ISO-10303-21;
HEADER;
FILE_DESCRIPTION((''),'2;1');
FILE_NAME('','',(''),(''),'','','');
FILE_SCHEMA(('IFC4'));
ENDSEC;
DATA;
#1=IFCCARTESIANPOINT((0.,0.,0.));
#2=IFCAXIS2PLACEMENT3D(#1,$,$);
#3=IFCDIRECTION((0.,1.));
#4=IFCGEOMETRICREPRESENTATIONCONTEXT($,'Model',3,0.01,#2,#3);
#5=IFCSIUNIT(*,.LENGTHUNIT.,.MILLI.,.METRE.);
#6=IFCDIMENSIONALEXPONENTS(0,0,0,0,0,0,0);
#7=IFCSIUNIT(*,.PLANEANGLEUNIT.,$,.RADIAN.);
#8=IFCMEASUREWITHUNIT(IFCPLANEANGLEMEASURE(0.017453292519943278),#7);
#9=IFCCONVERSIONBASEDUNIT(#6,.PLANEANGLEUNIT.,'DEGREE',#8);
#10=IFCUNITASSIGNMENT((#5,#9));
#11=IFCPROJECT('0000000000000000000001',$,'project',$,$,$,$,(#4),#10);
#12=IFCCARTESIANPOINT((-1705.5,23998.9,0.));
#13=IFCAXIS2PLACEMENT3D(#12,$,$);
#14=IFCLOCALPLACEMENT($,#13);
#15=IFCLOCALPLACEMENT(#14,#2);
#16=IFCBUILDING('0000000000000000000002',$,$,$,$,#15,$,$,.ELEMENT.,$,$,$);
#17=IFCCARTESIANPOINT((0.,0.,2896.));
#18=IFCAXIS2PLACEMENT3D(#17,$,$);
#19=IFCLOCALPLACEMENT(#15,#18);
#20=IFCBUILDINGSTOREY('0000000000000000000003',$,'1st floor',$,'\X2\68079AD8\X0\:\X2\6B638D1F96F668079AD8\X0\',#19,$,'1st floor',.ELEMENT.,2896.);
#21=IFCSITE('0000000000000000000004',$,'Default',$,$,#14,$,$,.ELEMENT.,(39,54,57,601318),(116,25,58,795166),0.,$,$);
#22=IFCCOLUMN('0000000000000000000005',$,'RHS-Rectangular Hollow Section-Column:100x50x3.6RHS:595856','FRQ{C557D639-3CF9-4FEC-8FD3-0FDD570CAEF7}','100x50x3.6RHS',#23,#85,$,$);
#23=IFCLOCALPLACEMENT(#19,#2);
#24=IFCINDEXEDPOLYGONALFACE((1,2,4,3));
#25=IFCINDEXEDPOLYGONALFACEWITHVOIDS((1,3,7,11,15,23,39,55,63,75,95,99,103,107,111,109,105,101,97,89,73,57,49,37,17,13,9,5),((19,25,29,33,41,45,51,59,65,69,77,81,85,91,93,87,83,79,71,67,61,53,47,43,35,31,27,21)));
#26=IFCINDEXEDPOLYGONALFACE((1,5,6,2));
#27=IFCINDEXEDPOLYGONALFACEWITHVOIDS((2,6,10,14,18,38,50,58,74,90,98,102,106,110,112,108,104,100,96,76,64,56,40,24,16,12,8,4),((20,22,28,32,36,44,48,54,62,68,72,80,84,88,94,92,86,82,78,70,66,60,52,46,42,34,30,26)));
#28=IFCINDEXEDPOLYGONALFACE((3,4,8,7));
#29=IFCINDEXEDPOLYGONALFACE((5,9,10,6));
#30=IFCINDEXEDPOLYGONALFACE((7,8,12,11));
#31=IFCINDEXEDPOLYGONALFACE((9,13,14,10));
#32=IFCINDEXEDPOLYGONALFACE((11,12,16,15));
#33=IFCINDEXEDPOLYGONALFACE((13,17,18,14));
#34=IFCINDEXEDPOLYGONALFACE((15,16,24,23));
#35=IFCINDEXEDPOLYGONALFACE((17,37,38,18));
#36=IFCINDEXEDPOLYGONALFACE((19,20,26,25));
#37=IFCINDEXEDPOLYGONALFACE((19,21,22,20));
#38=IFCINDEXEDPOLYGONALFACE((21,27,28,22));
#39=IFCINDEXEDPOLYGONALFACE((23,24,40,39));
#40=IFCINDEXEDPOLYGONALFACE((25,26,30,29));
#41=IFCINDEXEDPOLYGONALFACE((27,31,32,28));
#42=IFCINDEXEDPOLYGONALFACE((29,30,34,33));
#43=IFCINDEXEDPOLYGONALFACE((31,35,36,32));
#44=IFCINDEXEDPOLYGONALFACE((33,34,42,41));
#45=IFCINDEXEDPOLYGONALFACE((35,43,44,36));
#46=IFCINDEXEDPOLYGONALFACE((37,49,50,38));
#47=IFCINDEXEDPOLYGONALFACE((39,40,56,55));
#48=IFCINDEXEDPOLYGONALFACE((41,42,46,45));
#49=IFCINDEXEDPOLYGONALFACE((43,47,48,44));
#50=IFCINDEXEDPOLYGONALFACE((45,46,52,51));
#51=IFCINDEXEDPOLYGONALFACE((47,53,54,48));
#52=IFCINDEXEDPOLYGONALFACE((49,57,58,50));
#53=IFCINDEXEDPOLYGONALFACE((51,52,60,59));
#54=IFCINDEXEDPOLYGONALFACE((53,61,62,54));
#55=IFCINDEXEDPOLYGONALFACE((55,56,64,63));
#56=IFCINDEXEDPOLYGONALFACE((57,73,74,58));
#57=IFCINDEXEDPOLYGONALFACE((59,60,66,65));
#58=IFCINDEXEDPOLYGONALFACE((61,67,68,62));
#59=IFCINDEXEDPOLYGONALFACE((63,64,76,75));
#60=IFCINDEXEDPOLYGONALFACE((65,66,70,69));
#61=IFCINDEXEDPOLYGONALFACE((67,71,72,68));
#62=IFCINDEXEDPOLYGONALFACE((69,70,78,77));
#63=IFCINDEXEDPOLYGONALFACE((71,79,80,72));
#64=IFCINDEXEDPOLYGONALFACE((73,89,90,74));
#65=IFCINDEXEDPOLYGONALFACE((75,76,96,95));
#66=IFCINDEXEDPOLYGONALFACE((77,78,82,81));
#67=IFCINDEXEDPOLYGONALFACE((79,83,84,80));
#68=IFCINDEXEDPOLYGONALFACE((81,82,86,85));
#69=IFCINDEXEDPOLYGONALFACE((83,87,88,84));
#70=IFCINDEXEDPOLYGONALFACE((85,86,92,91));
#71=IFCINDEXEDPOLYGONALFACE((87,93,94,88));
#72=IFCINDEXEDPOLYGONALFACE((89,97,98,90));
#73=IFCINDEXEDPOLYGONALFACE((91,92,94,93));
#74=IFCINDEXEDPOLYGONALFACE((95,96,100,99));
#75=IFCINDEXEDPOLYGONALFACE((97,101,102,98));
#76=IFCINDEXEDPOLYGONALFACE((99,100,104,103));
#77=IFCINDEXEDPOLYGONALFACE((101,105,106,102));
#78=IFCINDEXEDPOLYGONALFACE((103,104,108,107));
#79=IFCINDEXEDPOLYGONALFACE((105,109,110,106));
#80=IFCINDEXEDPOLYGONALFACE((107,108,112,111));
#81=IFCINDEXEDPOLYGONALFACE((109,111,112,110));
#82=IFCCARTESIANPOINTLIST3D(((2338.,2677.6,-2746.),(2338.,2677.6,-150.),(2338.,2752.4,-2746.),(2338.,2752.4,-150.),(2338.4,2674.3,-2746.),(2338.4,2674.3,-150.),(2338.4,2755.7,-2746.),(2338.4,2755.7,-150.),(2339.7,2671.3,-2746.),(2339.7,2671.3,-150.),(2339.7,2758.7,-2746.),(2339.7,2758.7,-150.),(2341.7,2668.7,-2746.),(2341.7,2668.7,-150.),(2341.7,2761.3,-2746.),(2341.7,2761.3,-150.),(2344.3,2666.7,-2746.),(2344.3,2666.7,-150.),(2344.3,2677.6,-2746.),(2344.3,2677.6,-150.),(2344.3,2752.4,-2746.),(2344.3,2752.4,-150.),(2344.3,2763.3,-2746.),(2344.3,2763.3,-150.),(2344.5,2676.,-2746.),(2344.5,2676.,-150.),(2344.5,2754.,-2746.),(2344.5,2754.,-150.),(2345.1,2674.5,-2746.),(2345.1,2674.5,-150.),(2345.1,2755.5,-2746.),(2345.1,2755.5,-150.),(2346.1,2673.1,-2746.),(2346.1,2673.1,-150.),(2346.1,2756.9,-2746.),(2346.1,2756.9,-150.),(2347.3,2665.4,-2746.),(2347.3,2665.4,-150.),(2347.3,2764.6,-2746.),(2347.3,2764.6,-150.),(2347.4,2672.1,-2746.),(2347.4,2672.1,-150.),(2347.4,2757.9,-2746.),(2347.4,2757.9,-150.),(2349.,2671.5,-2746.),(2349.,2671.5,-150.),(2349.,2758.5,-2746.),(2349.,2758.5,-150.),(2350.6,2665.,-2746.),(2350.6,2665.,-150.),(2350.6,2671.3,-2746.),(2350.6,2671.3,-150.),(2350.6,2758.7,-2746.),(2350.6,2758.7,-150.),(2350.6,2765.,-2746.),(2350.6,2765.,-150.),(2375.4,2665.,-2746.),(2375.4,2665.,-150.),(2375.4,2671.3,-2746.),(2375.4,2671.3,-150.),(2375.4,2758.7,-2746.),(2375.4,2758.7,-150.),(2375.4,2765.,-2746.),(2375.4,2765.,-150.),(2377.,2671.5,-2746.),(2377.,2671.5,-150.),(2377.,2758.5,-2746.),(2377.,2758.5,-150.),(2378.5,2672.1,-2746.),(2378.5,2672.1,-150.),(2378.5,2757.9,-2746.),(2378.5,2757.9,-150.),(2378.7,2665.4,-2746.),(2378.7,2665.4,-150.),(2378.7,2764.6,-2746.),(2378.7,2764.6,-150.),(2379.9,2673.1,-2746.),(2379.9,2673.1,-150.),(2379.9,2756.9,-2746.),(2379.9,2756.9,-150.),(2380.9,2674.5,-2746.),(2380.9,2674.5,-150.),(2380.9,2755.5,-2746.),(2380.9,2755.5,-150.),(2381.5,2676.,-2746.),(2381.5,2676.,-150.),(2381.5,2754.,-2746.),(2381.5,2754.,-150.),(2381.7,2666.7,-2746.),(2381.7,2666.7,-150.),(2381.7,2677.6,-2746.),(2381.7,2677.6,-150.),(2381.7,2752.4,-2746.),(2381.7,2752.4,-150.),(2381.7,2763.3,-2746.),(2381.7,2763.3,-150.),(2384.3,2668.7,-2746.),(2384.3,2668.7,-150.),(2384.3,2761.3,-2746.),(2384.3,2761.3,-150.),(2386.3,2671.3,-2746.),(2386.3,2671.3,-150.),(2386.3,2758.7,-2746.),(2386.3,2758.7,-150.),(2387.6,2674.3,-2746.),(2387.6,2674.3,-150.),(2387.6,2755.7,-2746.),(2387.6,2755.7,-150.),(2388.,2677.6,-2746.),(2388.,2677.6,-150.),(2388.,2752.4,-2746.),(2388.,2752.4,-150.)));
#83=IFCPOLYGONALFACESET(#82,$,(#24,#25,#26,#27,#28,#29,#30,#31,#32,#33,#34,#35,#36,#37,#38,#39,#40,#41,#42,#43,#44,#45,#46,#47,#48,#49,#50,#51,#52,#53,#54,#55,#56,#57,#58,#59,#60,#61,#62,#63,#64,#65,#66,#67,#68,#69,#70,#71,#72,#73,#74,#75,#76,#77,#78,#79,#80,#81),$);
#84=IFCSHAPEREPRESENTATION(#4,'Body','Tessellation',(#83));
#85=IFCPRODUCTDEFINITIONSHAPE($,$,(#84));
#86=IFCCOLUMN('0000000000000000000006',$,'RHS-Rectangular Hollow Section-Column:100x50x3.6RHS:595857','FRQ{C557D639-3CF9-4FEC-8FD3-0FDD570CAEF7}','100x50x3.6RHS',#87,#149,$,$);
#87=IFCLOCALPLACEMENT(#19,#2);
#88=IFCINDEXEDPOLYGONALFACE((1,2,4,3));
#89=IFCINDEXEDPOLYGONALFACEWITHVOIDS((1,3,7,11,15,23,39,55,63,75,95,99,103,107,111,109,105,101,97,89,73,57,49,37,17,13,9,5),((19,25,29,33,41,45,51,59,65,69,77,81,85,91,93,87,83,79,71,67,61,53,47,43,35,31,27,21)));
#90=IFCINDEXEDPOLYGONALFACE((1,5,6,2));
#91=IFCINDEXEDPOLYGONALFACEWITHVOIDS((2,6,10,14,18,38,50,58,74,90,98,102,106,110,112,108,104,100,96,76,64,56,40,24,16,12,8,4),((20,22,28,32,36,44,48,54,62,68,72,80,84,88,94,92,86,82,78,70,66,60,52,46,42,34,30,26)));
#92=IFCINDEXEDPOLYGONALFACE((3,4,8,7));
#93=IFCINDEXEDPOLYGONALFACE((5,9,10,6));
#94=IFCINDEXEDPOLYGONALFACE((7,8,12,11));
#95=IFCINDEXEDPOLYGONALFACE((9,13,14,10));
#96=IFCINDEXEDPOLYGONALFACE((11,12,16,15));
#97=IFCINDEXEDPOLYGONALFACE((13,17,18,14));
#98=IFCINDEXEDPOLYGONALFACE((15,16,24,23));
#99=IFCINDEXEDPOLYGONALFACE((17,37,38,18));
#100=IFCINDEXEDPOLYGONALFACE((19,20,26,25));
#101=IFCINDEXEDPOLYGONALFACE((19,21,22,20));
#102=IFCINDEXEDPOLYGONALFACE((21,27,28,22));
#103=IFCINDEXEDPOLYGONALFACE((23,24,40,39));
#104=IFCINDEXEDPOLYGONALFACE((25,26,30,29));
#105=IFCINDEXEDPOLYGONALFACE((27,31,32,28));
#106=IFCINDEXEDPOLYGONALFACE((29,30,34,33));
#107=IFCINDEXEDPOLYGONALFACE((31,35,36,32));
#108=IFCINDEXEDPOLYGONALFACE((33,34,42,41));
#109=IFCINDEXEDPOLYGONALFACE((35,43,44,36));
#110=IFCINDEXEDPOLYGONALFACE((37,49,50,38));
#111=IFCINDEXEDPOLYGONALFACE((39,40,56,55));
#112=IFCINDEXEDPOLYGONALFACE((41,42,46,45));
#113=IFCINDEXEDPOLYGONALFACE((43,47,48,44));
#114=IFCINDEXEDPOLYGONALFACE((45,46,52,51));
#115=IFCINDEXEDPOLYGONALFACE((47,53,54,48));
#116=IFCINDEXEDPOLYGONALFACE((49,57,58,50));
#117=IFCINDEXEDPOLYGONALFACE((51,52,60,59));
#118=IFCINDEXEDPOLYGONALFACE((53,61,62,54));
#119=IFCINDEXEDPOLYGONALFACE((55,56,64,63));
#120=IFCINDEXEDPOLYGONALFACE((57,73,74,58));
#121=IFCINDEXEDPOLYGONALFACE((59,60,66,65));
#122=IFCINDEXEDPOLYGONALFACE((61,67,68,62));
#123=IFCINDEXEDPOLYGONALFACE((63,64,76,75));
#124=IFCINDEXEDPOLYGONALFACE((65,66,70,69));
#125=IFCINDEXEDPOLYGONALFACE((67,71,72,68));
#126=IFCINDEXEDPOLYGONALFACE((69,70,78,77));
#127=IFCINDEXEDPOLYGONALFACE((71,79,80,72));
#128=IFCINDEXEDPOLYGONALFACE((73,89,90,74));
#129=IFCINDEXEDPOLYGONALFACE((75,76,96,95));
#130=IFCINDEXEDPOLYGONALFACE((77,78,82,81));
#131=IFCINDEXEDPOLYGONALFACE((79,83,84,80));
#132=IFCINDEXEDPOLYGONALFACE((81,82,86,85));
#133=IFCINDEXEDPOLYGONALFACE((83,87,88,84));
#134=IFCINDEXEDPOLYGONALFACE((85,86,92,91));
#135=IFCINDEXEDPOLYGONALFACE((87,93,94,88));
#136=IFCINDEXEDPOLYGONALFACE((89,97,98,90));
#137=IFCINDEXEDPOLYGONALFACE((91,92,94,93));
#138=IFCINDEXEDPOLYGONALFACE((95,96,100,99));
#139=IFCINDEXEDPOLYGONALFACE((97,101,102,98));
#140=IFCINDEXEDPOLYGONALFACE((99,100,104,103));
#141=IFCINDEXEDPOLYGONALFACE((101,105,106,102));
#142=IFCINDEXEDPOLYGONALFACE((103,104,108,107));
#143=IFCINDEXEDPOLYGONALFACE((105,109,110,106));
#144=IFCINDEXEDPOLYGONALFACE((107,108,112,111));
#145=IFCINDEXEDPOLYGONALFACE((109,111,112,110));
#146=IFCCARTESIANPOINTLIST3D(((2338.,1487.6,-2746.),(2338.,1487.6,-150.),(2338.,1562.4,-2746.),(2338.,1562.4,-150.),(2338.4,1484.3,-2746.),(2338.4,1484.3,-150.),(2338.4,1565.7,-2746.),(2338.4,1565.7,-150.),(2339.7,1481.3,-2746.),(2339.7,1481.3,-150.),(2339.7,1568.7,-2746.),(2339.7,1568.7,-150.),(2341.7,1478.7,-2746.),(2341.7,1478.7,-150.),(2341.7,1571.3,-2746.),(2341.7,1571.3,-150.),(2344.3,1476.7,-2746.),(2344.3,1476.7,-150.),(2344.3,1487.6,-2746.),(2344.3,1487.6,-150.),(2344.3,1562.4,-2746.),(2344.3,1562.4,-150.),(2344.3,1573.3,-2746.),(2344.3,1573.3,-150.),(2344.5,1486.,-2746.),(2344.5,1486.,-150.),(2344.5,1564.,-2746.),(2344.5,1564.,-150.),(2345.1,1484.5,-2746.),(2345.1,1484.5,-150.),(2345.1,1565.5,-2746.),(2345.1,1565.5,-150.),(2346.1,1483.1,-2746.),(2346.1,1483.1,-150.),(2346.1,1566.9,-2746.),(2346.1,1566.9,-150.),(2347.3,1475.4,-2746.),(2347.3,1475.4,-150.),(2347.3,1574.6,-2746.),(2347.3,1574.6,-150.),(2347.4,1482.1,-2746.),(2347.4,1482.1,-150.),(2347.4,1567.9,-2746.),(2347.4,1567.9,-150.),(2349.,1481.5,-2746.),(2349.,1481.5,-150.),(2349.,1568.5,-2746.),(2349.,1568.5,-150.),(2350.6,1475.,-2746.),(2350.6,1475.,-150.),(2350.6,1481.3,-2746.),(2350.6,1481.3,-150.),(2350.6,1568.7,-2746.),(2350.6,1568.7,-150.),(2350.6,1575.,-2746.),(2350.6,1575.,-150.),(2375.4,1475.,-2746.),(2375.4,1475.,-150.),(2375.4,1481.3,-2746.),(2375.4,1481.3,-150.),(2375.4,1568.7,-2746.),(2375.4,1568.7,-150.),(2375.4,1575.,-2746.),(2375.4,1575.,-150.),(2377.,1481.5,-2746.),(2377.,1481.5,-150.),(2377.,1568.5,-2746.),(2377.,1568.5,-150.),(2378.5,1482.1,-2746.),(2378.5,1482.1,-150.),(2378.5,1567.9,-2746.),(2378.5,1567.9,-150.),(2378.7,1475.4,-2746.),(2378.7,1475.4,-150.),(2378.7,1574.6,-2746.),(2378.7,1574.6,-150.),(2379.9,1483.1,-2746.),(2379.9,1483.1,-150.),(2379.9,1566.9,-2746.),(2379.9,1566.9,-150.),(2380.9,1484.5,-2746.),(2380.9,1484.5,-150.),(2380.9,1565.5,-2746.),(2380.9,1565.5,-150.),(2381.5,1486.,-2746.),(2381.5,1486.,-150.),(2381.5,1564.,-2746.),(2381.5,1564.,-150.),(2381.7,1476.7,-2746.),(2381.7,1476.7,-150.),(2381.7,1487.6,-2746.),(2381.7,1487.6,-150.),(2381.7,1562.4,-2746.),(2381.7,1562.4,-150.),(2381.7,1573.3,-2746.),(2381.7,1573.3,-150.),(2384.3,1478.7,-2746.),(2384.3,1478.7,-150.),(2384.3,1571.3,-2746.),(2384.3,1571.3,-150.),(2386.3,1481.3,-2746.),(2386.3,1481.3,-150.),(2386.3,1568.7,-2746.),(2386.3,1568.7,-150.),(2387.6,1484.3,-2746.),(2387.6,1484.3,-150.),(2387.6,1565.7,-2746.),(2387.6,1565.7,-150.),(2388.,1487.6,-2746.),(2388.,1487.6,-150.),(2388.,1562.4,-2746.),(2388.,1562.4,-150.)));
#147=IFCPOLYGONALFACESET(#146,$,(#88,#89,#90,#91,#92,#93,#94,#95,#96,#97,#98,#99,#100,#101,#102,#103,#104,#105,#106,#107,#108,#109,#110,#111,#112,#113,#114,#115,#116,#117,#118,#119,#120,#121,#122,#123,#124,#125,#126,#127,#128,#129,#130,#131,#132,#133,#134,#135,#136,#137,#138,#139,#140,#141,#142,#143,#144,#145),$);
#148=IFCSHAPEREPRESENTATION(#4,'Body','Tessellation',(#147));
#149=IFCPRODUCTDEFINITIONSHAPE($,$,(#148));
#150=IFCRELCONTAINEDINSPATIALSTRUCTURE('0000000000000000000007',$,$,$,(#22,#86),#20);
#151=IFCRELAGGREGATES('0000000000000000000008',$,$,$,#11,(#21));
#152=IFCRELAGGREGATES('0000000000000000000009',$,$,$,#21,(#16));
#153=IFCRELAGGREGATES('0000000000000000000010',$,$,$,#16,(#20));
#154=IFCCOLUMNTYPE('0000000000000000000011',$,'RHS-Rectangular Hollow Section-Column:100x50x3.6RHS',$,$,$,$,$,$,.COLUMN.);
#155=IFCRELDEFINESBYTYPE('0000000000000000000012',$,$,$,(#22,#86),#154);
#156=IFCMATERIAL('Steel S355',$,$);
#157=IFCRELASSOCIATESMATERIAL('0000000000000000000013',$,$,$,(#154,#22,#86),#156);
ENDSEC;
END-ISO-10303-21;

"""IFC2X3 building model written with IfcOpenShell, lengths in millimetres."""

from ifc_helpers import new_model, entity, si_unit, converted_unit, direction, frame, origin, origin_2d, place, context, project, spatial, hollow_rectangle, extrude, clip, halfspace, material, type_object, element, save


model = new_model("IFC2X3")

# Units and contexts
model_context = context("Model", 3, precision=0.01, world=origin(), true_north=direction((0.0, 1.0)))
ifc_project = project(units=[si_unit("LENGTHUNIT", "METRE", prefix="MILLI"), converted_unit("PLANEANGLEUNIT", "DEGREE", entity("IfcPlaneAngleMeasure", 0.017453292519943278), si_unit("PLANEANGLEUNIT", "RADIAN"), dimensions=[0, 0, 0, 0, 0, 0, 0])], contexts=[model_context])

# Site, building, storey
site_placement = place(None, frame((-1705.5, 23998.9, 0.0)))
site = spatial("IfcSite", under=ifc_project, at=site_placement, Name="Default", CompositionType="ELEMENT", RefLatitude=(39, 54, 57, 601318), RefLongitude=(116, 25, 58, 795166), RefElevation=0.0)
building_placement = place(site_placement, origin())
building = spatial("IfcBuilding", under=site, at=building_placement, CompositionType="ELEMENT")
storey_placement = place(building_placement, frame((0.0, 0.0, 2896.0)))
storey = spatial("IfcBuildingStorey", under=building, at=storey_placement, Name="1st floor", ObjectType="标高:正负零标高", LongName="1st floor", CompositionType="ELEMENT", Elevation=2896.0)

# Shared definitions
ifc_material_1 = material(Name="Steel S355")

# Columns
column_type_1 = type_object("IfcColumnType", Name="RHS-Rectangular Hollow Section-Column:100x50x3.6RHS", PredefinedType="COLUMN", material=ifc_material_1)
column_1_placement = place(storey_placement, frame((2363.0, 2715.0, -150.0), z_axis=(0.0, 0.0, 1.0), x_axis=(-1.0, 0.0, 0.0)))
element("IfcColumn", 1, at=column_1_placement, inside=storey, type_object=column_type_1, material=ifc_material_1, Name="RHS-Rectangular Hollow Section-Column:100x50x3.6RHS:595856", Description="FRQ{C557D639-3CF9-4FEC-8FD3-0FDD570CAEF7}", ObjectType="100x50x3.6RHS", context=model_context, shape_type="Clipping", body=[
    clip(extrude(hollow_rectangle(XDim=50.0, YDim=100.0, WallThickness=6.3, InnerFilletRadius=6.3, OuterFilletRadius=12.6, at=origin_2d()), origin(), (0.0, 0.0, -1.0), 2651.9), halfspace(frame((2363.0, 2715.0, -2596.0), z_axis=(0.0, 0.0, 1.0), x_axis=(-1.0, 0.0, 0.0)), True)),
])
column_2_placement = place(storey_placement, frame((2363.0, 1525.0, -150.0), z_axis=(0.0, 0.0, 1.0), x_axis=(-1.0, 0.0, 0.0)))
element("IfcColumn", 2, at=column_2_placement, inside=storey, type_object=column_type_1, material=ifc_material_1, Name="RHS-Rectangular Hollow Section-Column:100x50x3.6RHS:595857", Description="FRQ{C557D639-3CF9-4FEC-8FD3-0FDD570CAEF7}", ObjectType="100x50x3.6RHS", context=model_context, shape_type="Clipping", body=[
    clip(extrude(hollow_rectangle(XDim=50.0, YDim=100.0, WallThickness=6.3, InnerFilletRadius=6.3, OuterFilletRadius=12.6, at=origin_2d()), origin(), (0.0, 0.0, -1.0), 2651.9), halfspace(frame((2363.0, 1525.0, -2596.0), z_axis=(0.0, 0.0, 1.0), x_axis=(-1.0, 0.0, 0.0)), True)),
])

save(model, "model.ifc")
